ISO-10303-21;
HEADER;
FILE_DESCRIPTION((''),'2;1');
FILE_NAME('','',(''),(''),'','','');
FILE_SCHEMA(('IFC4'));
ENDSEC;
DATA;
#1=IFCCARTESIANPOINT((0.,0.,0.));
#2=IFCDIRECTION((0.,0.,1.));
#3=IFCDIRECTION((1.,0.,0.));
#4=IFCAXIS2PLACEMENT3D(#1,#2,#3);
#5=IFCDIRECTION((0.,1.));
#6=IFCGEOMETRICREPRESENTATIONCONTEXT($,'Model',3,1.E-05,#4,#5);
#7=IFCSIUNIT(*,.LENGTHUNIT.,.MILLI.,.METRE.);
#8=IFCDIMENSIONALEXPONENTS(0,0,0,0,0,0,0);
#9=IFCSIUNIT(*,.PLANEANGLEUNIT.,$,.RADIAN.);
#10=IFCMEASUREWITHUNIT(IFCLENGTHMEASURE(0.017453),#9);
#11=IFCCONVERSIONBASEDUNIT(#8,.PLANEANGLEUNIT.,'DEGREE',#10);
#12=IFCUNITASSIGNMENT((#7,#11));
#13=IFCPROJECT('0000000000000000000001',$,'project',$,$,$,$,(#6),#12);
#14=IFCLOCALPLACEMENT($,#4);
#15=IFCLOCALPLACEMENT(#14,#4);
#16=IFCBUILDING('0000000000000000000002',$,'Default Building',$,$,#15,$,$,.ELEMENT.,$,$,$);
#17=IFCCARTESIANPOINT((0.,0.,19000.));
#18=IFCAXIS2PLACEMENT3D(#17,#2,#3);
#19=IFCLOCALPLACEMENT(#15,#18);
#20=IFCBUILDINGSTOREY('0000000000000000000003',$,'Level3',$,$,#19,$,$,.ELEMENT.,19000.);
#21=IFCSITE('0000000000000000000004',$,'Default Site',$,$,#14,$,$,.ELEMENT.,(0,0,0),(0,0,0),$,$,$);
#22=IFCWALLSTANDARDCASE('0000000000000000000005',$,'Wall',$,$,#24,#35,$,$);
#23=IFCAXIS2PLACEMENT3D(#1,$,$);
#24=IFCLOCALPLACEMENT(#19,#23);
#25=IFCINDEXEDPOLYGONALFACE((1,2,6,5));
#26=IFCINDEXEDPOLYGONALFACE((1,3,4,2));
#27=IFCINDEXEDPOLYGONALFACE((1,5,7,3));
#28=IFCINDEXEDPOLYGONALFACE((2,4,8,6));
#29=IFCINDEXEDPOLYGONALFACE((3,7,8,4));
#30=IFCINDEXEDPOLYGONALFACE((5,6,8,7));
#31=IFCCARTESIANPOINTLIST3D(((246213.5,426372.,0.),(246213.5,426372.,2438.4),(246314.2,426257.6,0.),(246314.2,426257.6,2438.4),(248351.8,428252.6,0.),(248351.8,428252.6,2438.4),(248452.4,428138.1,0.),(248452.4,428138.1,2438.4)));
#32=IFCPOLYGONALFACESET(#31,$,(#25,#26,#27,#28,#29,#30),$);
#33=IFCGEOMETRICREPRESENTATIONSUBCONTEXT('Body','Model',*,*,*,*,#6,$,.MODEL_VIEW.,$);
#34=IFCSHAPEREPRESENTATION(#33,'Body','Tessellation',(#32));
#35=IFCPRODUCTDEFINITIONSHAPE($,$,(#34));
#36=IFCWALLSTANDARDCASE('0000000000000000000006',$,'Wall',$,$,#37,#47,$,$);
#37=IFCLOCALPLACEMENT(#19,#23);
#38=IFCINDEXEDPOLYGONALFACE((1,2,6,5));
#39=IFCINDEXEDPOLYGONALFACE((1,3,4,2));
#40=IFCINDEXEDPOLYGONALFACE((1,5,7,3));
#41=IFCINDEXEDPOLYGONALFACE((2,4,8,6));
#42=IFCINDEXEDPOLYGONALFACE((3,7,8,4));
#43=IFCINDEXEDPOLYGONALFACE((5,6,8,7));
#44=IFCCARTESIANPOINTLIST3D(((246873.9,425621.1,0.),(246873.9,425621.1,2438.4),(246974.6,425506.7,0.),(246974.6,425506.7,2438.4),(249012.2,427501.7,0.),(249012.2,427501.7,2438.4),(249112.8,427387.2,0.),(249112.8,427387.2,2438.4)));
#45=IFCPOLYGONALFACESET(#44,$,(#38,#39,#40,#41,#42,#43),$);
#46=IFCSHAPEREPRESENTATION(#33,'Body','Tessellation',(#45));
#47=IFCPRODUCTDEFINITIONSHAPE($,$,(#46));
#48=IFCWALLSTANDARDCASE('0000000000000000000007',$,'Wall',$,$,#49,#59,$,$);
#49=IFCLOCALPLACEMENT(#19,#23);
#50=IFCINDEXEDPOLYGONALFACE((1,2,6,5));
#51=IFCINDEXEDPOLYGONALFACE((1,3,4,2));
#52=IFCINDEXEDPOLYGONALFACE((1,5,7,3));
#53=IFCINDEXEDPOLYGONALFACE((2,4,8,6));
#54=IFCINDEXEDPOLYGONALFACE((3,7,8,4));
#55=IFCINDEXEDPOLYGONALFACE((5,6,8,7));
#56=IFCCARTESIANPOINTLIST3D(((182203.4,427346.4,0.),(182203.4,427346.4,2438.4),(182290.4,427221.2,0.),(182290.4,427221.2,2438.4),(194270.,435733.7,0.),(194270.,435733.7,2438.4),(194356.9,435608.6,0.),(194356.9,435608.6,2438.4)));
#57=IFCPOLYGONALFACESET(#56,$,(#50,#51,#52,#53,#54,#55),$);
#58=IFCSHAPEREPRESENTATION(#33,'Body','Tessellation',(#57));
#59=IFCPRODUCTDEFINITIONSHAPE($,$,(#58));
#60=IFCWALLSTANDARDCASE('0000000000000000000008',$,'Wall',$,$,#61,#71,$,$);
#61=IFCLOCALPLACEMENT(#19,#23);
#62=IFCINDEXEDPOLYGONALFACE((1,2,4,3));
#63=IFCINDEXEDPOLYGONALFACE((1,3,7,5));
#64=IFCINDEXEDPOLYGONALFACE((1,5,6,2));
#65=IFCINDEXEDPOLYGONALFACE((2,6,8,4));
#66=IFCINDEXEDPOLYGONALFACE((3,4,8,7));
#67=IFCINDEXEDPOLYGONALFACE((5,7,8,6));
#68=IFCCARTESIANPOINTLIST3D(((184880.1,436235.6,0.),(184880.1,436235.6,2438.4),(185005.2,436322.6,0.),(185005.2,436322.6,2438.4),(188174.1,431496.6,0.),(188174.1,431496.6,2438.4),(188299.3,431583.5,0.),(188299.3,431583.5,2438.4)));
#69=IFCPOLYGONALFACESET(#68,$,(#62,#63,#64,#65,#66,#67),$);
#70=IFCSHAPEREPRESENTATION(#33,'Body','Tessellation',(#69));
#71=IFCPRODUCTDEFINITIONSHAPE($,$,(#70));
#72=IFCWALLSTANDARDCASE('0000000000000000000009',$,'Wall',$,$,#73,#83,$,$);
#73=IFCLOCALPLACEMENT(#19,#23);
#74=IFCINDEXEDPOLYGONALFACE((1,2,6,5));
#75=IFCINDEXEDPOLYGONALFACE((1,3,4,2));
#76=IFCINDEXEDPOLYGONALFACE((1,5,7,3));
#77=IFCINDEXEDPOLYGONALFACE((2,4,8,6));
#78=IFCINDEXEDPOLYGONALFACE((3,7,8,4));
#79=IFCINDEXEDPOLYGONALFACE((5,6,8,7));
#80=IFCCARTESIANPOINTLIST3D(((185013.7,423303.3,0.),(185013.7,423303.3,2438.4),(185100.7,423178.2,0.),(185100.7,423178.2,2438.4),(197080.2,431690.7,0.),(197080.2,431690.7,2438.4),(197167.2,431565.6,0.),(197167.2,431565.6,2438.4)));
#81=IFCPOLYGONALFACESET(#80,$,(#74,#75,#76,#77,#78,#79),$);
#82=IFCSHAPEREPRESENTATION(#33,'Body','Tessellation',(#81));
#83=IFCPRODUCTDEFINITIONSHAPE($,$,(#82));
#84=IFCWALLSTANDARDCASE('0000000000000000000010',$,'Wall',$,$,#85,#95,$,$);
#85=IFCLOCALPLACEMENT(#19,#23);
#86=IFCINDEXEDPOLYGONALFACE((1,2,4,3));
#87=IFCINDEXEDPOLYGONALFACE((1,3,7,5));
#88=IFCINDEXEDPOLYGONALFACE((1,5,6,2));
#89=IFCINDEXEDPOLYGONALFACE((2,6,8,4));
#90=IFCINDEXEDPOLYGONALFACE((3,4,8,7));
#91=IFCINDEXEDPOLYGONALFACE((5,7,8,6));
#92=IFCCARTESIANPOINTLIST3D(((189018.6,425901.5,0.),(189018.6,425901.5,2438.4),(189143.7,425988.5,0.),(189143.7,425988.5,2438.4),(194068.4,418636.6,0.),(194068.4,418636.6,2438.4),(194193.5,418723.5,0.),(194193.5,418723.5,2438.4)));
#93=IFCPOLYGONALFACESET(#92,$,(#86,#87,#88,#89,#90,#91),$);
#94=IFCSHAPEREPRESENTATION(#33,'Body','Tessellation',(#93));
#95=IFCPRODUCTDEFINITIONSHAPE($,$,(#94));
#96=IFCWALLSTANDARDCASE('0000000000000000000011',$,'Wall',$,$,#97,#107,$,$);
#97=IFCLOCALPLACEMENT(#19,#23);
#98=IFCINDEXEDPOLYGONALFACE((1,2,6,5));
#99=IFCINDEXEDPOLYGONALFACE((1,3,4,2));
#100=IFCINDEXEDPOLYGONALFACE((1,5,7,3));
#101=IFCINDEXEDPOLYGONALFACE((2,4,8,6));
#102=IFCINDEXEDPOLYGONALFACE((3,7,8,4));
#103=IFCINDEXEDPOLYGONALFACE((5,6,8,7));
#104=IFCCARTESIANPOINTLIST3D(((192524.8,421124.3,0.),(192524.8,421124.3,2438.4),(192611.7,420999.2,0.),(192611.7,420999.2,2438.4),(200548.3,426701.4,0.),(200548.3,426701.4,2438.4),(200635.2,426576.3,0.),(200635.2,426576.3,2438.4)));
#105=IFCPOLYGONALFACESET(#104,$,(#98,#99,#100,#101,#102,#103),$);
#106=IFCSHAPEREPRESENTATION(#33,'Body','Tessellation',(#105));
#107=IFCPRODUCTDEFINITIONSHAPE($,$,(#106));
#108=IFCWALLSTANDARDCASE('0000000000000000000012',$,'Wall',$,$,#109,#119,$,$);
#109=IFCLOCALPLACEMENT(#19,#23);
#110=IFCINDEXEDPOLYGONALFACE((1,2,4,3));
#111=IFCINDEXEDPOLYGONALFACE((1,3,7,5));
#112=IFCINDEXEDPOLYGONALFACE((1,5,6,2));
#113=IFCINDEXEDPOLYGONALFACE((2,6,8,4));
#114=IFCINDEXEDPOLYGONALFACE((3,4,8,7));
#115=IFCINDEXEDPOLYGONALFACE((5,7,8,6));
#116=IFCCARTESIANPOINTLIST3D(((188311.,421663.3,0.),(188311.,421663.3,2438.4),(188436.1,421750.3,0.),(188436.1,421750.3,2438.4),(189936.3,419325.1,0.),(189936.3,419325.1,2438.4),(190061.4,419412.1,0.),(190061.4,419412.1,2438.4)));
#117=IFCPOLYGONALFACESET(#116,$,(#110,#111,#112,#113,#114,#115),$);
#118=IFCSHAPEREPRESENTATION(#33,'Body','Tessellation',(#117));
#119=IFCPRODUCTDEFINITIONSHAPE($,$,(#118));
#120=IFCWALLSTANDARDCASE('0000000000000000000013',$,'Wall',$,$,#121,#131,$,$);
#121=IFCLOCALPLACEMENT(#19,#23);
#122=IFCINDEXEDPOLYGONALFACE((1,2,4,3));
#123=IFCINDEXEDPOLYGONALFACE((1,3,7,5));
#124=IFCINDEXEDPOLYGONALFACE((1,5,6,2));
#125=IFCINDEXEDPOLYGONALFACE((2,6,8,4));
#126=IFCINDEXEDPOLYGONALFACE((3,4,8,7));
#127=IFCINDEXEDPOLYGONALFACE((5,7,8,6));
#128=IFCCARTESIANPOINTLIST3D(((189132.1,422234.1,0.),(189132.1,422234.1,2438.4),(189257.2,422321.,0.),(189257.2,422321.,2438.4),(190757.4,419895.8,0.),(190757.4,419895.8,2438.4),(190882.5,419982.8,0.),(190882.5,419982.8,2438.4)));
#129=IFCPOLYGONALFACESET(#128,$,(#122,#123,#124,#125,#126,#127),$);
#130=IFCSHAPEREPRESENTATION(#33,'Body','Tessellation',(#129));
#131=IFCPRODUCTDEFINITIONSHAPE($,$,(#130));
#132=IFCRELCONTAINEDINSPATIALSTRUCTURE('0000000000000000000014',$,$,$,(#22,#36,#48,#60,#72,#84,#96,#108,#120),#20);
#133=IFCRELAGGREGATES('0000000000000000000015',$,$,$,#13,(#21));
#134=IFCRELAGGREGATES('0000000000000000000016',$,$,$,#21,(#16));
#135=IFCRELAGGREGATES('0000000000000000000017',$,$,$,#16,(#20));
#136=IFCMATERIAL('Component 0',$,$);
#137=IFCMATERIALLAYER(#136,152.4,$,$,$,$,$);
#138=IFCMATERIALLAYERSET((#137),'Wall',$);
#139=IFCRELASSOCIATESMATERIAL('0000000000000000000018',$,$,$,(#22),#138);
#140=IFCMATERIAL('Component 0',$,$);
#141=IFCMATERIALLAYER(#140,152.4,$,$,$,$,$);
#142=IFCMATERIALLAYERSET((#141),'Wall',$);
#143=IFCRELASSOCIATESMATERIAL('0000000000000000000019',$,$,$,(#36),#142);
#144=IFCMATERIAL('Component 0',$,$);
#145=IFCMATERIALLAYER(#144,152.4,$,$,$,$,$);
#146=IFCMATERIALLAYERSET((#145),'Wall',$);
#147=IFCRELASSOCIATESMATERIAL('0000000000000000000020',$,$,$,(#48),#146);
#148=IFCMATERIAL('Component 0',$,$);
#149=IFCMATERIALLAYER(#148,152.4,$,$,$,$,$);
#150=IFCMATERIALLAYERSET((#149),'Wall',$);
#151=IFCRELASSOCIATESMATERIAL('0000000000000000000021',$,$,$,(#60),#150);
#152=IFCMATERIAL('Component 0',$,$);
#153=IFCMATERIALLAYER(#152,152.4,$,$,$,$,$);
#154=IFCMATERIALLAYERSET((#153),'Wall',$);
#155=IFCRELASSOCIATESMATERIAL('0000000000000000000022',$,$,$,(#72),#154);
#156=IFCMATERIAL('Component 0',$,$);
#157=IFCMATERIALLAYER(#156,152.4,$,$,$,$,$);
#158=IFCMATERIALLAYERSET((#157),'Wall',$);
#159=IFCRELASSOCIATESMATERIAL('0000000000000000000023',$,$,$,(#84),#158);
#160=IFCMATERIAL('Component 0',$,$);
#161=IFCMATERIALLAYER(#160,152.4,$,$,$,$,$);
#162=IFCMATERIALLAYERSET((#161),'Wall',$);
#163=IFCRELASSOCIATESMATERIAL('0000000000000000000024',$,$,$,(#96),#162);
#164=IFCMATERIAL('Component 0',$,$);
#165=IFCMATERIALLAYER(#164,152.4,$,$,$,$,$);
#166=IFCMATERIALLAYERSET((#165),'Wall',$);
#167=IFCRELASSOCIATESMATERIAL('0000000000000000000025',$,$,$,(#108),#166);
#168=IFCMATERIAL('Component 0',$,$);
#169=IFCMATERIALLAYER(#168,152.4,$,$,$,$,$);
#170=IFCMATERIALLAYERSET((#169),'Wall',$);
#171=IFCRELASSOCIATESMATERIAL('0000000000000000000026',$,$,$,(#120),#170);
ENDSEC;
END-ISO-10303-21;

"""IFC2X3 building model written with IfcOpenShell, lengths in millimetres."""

from ifc_helpers import new_model, entity, si_unit, converted_unit, direction, frame, origin_with_axes, place, context, subcontext, project, spatial, polyline, outline, extrude, material, layer, layer_set, layer_usage, element, save


model = new_model("IFC2X3")

# Units and contexts
model_context = context("Model", 3, precision=1e-05, world=origin_with_axes(), true_north=direction((0.0, 1.0)))
body_context = subcontext(model_context, "Body", "Model", "MODEL_VIEW")
ifc_project = project(units=[si_unit("LENGTHUNIT", "METRE", prefix="MILLI"), converted_unit("PLANEANGLEUNIT", "DEGREE", entity("IfcLengthMeasure", 0.017453), si_unit("PLANEANGLEUNIT", "RADIAN"), dimensions=[0, 0, 0, 0, 0, 0, 0])], contexts=[model_context])

# Site, building, storey
site_placement = place(None, origin_with_axes())
site = spatial("IfcSite", under=ifc_project, at=site_placement, Name="Default Site", CompositionType="ELEMENT", RefLatitude=(0, 0, 0), RefLongitude=(0, 0, 0))
building_placement = place(site_placement, origin_with_axes())
building = spatial("IfcBuilding", under=site, at=building_placement, Name="Default Building", CompositionType="ELEMENT")
storey_placement = place(building_placement, frame((0.0, 0.0, 19000.0), z_axis=(0.0, 0.0, 1.0), x_axis=(1.0, 0.0, 0.0)))
storey = spatial("IfcBuildingStorey", under=building, at=storey_placement, Name="Level3", CompositionType="ELEMENT", Elevation=19000.0)

# Walls
ifc_material_1 = material(Name="Component 0")
ifc_layer_1 = layer(ifc_material_1, 152.4)
ifc_layer_set_1 = layer_set([ifc_layer_1], Name="Wall")
ifc_layer_usage_1 = layer_usage(ifc_layer_set_1, "AXIS2", "POSITIVE", -76.2)
wall_1_placement = place(storey_placement, frame((246206.6, 426264.5, 0.0), z_axis=(0.0, 0.0, 1.0), x_axis=(0.750906, 0.660409, 0.0)))
element("IfcWallStandardCase", 1, at=wall_1_placement, inside=storey, material=ifc_layer_usage_1, Name="Wall", context=body_context, shape_type="SweptSolid", body=[
    extrude(outline(polyline([(76.2, -76.2), (76.2, 76.2), (2923.8, 76.2), (2923.8, -76.2), (76.2, -76.2)])), origin_with_axes(), (0.0, 0.0, 1.0), 2438.4),
])
ifc_material_2 = material(Name="Component 0")
ifc_layer_2 = layer(ifc_material_2, 152.4)
ifc_layer_set_2 = layer_set([ifc_layer_2], Name="Wall")
ifc_layer_usage_2 = layer_usage(ifc_layer_set_2, "AXIS2", "POSITIVE", -76.2)
wall_2_placement = place(storey_placement, frame((246867.0, 425513.6, 0.0), z_axis=(0.0, 0.0, 1.0), x_axis=(0.750906, 0.660409, 0.0)))
element("IfcWallStandardCase", 2, at=wall_2_placement, inside=storey, material=ifc_layer_usage_2, Name="Wall", context=body_context, shape_type="SweptSolid", body=[
    extrude(outline(polyline([(76.2, -76.2), (76.2, 76.2), (2923.8, 76.2), (2923.8, -76.2), (76.2, -76.2)])), origin_with_axes(), (0.0, 0.0, 1.0), 2438.4),
])
ifc_material_3 = material(Name="Component 0")
ifc_layer_3 = layer(ifc_material_3, 152.4)
ifc_layer_set_3 = layer_set([ifc_layer_3], Name="Wall")
ifc_layer_usage_3 = layer_usage(ifc_layer_set_3, "AXIS2", "POSITIVE", -76.2)
wall_3_placement = place(storey_placement, frame((182184.3, 427240.3, 0.0), z_axis=(0.0, 0.0, 1.0), x_axis=(0.82112, 0.570755, 0.0)))
element("IfcWallStandardCase", 3, at=wall_3_placement, inside=storey, material=ifc_layer_usage_3, Name="Wall", context=body_context, shape_type="SweptSolid", body=[
    extrude(outline(polyline([(76.2, -76.2), (76.2, 76.2), (14771.4, 76.2), (14771.4, -76.2), (76.2, -76.2)])), origin_with_axes(), (0.0, 0.0, 1.0), 2438.4),
])
ifc_material_4 = material(Name="Component 0")
ifc_layer_4 = layer(ifc_material_4, 152.4)
ifc_layer_set_4 = layer_set([ifc_layer_4], Name="Wall")
ifc_layer_usage_4 = layer_usage(ifc_layer_set_4, "AXIS2", "POSITIVE", -76.2)
wall_4_placement = place(storey_placement, frame((184899.1, 436341.6, 0.0), z_axis=(0.0, 0.0, 1.0), x_axis=(0.570755, -0.82112, 0.0)))
element("IfcWallStandardCase", 4, at=wall_4_placement, inside=storey, material=ifc_layer_usage_4, Name="Wall", context=body_context, shape_type="SweptSolid", body=[
    extrude(outline(polyline([(76.2, -76.2), (76.2, 76.2), (5847.6, 76.2), (5847.6, -76.2), (76.2, -76.2)])), origin_with_axes(), (0.0, 0.0, 1.0), 2438.4),
])
ifc_material_5 = material(Name="Component 0")
ifc_layer_5 = layer(ifc_material_5, 152.4)
ifc_layer_set_5 = layer_set([ifc_layer_5], Name="Wall")
ifc_layer_usage_5 = layer_usage(ifc_layer_set_5, "AXIS2", "POSITIVE", -76.2)
wall_5_placement = place(storey_placement, frame((197186.3, 431671.6, 0.0), z_axis=(0.0, 0.0, 1.0), x_axis=(-0.82112, -0.570755, 0.0)))
element("IfcWallStandardCase", 5, at=wall_5_placement, inside=storey, material=ifc_layer_usage_5, Name="Wall", context=body_context, shape_type="SweptSolid", body=[
    extrude(outline(polyline([(76.2, -76.2), (76.2, 76.2), (14771.4, 76.2), (14771.4, -76.2), (76.2, -76.2)])), origin_with_axes(), (0.0, 0.0, 1.0), 2438.4),
])
ifc_material_6 = material(Name="Component 0")
ifc_layer_6 = layer(ifc_material_6, 152.4)
ifc_layer_set_6 = layer_set([ifc_layer_6], Name="Wall")
ifc_layer_usage_6 = layer_usage(ifc_layer_set_6, "AXIS2", "POSITIVE", -76.2)
wall_6_placement = place(storey_placement, frame((189037.7, 426007.6, 0.0), z_axis=(0.0, 0.0, 1.0), x_axis=(0.570755, -0.82112, 0.0)))
element("IfcWallStandardCase", 6, at=wall_6_placement, inside=storey, material=ifc_layer_usage_6, Name="Wall", context=body_context, shape_type="SweptSolid", body=[
    extrude(outline(polyline([(76.2, -76.2), (76.2, 76.2), (8923.8, 76.2), (8923.8, -76.2), (76.2, -76.2)])), origin_with_axes(), (0.0, 0.0, 1.0), 2438.4),
])
ifc_material_7 = material(Name="Component 0")
ifc_layer_7 = layer(ifc_material_7, 152.4)
ifc_layer_set_7 = layer_set([ifc_layer_7], Name="Wall")
ifc_layer_usage_7 = layer_usage(ifc_layer_set_7, "AXIS2", "POSITIVE", -76.2)
wall_7_placement = place(storey_placement, frame((200654.3, 426682.3, 0.0), z_axis=(0.0, 0.0, 1.0), x_axis=(-0.82112, -0.570755, 0.0)))
element("IfcWallStandardCase", 7, at=wall_7_placement, inside=storey, material=ifc_layer_usage_7, Name="Wall", context=body_context, shape_type="SweptSolid", body=[
    extrude(outline(polyline([(76.2, -76.2), (76.2, 76.2), (9847.6, 76.2), (9847.6, -76.2), (76.2, -76.2)])), origin_with_axes(), (0.0, 0.0, 1.0), 2438.4),
])
ifc_material_8 = material(Name="Component 0")
ifc_layer_8 = layer(ifc_material_8, 152.4)
ifc_layer_set_8 = layer_set([ifc_layer_8], Name="Wall")
ifc_layer_usage_8 = layer_usage(ifc_layer_set_8, "AXIS2", "POSITIVE", -76.2)
wall_8_placement = place(storey_placement, frame((188330.1, 421769.4, 0.0), z_axis=(0.0, 0.0, 1.0), x_axis=(0.570755, -0.82112, 0.0)))
element("IfcWallStandardCase", 8, at=wall_8_placement, inside=storey, material=ifc_layer_usage_8, Name="Wall", context=body_context, shape_type="SweptSolid", body=[
    extrude(outline(polyline([(76.2, -76.2), (76.2, 76.2), (2923.8, 76.2), (2923.8, -76.2), (76.2, -76.2)])), origin_with_axes(), (0.0, 0.0, 1.0), 2438.4),
])
ifc_material_9 = material(Name="Component 0")
ifc_layer_9 = layer(ifc_material_9, 152.4)
ifc_layer_set_9 = layer_set([ifc_layer_9], Name="Wall")
ifc_layer_usage_9 = layer_usage(ifc_layer_set_9, "AXIS2", "POSITIVE", -76.2)
wall_9_placement = place(storey_placement, frame((189151.2, 422340.1, 0.0), z_axis=(0.0, 0.0, 1.0), x_axis=(0.570755, -0.82112, 0.0)))
element("IfcWallStandardCase", 9, at=wall_9_placement, inside=storey, material=ifc_layer_usage_9, Name="Wall", context=body_context, shape_type="SweptSolid", body=[
    extrude(outline(polyline([(76.2, -76.2), (76.2, 76.2), (2923.8, 76.2), (2923.8, -76.2), (76.2, -76.2)])), origin_with_axes(), (0.0, 0.0, 1.0), 2438.4),
])

save(model, "model.ifc")
